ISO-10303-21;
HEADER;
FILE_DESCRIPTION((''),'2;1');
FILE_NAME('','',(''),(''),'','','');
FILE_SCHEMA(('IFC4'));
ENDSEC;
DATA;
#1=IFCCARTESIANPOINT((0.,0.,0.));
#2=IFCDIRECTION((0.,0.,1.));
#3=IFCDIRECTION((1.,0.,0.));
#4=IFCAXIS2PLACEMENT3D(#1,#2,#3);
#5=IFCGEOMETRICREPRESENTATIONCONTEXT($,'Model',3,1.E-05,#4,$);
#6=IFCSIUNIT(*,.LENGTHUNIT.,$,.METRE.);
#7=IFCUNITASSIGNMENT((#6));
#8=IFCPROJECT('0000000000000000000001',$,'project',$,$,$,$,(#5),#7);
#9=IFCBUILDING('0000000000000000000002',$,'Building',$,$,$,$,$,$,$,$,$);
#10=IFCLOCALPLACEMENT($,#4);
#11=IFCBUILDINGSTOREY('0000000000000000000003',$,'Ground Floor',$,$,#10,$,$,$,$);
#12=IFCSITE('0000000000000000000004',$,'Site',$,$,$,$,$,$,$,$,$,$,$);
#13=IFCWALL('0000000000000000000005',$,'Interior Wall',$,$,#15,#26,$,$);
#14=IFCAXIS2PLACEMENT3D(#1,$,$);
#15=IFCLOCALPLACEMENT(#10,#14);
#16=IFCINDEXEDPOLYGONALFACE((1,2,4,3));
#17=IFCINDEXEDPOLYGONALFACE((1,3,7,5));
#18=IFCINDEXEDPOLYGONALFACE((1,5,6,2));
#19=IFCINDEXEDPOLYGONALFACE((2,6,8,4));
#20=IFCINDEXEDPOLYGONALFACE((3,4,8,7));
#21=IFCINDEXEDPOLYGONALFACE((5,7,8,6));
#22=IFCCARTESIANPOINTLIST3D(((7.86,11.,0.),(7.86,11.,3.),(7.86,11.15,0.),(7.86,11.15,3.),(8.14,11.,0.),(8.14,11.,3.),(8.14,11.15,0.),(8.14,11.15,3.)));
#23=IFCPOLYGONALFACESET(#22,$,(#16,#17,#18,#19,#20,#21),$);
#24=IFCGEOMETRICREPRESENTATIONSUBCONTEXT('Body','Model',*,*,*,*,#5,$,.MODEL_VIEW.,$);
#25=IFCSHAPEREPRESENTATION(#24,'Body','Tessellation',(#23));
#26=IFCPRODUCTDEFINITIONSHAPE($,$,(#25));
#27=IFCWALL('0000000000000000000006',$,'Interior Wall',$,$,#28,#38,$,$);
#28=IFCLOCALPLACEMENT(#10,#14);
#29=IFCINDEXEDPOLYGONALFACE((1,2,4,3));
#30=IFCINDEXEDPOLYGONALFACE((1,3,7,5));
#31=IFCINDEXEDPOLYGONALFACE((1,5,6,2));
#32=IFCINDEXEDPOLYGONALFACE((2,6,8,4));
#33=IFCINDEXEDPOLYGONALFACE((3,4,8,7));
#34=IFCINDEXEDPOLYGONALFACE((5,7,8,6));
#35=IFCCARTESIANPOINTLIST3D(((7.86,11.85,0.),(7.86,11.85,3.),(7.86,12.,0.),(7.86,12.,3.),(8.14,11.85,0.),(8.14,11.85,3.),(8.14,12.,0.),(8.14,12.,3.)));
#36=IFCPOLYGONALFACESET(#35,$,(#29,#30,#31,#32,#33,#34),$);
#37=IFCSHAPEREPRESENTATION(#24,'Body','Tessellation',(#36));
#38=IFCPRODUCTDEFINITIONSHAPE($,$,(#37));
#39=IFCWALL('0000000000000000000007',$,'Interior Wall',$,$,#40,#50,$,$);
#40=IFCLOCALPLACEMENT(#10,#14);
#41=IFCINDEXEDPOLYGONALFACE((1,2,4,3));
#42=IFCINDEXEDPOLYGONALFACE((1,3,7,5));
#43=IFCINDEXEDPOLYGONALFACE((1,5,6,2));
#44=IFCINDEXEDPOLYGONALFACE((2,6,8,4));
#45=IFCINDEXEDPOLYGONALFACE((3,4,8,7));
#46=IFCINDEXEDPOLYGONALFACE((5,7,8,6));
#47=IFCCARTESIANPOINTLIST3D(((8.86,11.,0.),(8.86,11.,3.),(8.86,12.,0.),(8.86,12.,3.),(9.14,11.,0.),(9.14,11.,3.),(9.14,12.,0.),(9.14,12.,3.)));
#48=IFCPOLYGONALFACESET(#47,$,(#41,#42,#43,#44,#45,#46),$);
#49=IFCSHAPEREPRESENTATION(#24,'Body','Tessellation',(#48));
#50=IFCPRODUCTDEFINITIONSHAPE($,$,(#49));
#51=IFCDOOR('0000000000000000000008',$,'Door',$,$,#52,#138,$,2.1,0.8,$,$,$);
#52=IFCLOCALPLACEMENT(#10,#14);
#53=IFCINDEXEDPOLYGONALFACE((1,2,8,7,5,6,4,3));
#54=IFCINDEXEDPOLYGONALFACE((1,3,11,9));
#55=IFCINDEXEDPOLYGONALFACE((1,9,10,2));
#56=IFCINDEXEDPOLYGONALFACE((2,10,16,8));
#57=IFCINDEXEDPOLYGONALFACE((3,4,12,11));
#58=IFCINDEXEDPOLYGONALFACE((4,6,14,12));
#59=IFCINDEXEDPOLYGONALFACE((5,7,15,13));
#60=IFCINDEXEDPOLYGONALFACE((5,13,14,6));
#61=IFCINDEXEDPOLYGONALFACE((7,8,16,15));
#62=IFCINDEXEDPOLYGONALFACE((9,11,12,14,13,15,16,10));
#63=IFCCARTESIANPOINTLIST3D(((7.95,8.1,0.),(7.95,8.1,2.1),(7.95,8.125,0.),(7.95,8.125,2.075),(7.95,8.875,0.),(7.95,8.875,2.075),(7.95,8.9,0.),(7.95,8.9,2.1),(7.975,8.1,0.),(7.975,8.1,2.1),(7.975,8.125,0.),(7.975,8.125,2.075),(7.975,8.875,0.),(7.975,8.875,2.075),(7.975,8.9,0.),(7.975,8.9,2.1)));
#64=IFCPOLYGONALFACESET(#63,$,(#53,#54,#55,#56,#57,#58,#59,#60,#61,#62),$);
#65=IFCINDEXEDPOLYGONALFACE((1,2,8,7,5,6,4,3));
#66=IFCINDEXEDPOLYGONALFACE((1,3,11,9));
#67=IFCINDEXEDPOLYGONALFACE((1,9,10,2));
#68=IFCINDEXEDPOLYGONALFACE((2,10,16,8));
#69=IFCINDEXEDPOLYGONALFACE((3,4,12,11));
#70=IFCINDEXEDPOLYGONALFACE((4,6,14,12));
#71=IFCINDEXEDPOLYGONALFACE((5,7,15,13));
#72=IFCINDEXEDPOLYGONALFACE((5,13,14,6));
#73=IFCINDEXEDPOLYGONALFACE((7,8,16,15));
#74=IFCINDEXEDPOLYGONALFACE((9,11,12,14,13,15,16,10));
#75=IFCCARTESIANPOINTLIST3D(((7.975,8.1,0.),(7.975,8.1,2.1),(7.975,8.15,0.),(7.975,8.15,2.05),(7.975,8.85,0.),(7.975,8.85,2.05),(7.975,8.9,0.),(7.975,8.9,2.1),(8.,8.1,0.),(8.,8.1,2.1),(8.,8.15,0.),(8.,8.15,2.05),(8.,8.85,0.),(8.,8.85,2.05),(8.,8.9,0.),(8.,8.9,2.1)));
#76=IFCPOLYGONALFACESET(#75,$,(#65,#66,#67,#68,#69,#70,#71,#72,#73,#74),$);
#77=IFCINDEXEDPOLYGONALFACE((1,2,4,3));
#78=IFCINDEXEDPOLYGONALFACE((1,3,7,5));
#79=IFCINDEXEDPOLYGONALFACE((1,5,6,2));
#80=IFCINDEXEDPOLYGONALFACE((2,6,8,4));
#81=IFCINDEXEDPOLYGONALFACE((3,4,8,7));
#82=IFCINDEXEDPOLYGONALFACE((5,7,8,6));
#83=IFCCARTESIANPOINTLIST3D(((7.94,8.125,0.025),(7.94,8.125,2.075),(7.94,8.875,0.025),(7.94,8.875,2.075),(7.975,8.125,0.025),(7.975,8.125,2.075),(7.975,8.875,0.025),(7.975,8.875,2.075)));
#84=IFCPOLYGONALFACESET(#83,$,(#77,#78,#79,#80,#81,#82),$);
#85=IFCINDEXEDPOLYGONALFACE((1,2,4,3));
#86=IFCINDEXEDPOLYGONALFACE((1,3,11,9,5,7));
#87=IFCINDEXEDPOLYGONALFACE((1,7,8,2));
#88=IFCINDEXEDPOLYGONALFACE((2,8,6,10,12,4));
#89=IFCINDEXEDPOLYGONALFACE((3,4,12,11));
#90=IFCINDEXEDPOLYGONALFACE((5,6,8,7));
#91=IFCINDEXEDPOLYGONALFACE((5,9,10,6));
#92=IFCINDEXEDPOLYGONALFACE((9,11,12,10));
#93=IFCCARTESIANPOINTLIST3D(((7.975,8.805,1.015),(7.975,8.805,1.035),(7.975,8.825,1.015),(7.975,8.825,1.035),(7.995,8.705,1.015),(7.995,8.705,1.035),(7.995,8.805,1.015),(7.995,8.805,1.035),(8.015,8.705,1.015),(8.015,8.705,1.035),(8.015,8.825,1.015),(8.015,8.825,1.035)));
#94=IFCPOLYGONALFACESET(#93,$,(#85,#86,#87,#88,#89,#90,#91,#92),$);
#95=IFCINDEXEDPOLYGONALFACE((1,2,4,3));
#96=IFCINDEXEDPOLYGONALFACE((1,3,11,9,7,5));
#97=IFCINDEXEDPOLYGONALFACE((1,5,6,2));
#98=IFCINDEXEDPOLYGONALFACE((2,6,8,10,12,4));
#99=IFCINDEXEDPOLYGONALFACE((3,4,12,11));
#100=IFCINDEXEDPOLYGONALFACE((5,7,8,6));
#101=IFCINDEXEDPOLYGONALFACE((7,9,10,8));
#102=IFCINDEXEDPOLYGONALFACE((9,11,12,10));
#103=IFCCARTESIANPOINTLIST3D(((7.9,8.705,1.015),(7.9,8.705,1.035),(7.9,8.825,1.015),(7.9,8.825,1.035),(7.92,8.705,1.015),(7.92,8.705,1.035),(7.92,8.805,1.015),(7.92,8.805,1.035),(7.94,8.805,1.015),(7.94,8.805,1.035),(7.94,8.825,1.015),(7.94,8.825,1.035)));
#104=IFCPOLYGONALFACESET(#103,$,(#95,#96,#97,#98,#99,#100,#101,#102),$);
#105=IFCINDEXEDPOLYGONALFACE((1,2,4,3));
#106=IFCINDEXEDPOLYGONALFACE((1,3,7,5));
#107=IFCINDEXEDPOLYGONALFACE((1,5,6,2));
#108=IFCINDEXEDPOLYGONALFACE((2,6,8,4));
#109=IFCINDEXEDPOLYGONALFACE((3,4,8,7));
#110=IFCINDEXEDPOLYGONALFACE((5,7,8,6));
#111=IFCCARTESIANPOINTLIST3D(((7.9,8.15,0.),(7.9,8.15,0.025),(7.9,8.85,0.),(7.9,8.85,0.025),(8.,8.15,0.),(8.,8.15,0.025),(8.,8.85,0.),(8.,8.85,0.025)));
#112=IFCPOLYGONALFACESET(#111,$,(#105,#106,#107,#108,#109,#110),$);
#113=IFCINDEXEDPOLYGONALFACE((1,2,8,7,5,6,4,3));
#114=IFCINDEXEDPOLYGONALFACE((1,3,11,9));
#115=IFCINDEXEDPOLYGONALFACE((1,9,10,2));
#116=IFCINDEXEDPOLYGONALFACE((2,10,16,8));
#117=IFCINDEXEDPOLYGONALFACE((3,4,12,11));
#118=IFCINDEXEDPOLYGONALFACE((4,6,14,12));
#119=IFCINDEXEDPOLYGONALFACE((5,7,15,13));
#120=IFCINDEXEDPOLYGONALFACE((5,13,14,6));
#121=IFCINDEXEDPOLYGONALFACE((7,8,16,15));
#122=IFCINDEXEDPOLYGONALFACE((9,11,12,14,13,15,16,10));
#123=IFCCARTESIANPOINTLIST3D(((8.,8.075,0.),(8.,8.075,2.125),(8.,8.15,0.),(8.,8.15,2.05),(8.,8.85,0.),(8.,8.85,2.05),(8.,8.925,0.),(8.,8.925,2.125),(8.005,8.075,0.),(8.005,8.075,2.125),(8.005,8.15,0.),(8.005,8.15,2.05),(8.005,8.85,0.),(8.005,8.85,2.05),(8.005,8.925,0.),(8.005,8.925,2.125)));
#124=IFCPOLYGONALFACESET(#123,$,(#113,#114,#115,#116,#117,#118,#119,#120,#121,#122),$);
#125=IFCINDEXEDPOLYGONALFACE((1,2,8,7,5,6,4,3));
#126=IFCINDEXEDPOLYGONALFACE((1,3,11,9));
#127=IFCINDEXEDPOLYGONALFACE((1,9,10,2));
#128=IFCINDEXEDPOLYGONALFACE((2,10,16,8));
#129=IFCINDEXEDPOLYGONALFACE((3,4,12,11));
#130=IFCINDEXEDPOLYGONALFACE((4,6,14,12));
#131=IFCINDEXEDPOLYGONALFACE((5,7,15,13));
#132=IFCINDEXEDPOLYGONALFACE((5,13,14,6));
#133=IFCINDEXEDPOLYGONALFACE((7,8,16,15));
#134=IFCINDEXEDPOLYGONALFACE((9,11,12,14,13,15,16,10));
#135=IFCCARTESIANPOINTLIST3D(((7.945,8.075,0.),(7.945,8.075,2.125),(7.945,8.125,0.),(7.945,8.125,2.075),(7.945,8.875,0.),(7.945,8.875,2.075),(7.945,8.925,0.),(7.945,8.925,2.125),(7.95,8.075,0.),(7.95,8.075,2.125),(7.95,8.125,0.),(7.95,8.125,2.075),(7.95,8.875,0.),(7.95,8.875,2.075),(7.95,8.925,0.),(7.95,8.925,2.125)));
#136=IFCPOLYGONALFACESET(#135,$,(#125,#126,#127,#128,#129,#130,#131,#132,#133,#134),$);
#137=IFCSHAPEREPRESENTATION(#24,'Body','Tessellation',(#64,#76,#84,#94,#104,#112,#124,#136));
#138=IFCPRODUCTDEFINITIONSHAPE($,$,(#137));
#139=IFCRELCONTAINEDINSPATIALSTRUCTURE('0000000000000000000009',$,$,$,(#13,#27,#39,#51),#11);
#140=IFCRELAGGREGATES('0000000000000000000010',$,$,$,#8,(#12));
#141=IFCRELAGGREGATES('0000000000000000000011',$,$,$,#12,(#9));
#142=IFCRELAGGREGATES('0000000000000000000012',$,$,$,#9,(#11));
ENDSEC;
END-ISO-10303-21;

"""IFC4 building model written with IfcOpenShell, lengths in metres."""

from ifc_helpers import new_model, si_unit, frame, origin_with_axes, place, context, subcontext, project, spatial, line, indexed_curve, outline, extrude, element, save


model = new_model("IFC4")

# Units and contexts
model_context = context("Model", 3, precision=1e-05, world=origin_with_axes())
body_context = subcontext(model_context, "Body", "Model", "MODEL_VIEW")
ifc_project = project(units=[si_unit("LENGTHUNIT", "METRE")], contexts=[model_context])

# Site, building, storey
site = spatial("IfcSite", under=ifc_project, Name="Site")
building = spatial("IfcBuilding", under=site, Name="Building")
storey_placement = place(None, origin_with_axes())
storey = spatial("IfcBuildingStorey", under=building, at=storey_placement, Name="Ground Floor")

# Walls
for number, where, z_axis, x_axis, name in (
    (1, (8.0, 11.0, 0.0), (0.0, 0.0, 1.0), (0.0, 1.0, 0.0), "Interior Wall"),
    (2, (8.0, 11.85, 0.0), (0.0, 0.0, 1.0), (0.0, 1.0, 0.0), "Interior Wall"),
):
    element("IfcWall", number, at=place(storey_placement, frame(where, z_axis=z_axis, x_axis=x_axis)), inside=storey, Name=name, context=body_context, shape_type="SweptSolid", body=[
        extrude(outline(indexed_curve([(0.0, 0.0), (0.0, 0.28), (0.15, 0.28), (0.15, 0.0), (0.0, 0.0)], self_intersect=False)), frame((0.0, -0.14, 0.0), z_axis=(0.0, 0.0, 1.0), x_axis=(1.0, 0.0, 0.0)), (0.0, 0.0, 1.0), 3.0),
    ])
wall_1_placement = place(storey_placement, frame((9.0, 12.0, 0.0), z_axis=(0.0, 0.0, 1.0), x_axis=(0.0, -1.0, 0.0)))
element("IfcWall", 3, at=wall_1_placement, inside=storey, Name="Interior Wall", context=body_context, shape_type="SweptSolid", body=[
    extrude(outline(indexed_curve([(0.0, 0.0), (0.0, 0.28), (1.0, 0.28), (1.0, 0.0), (0.0, 0.0)], self_intersect=False)), frame((0.0, -0.14, 0.0), z_axis=(0.0, 0.0, 1.0), x_axis=(1.0, 0.0, 0.0)), (0.0, 0.0, 1.0), 3.0),
])

# Door
door_1_placement = place(storey_placement, frame((8.0, 8.1, 0.0), z_axis=(0.0, 0.0, 1.0), x_axis=(0.0, 1.0, 0.0)))
element("IfcDoor", 4, at=door_1_placement, inside=storey, Name="Door", OverallHeight=2.1, OverallWidth=0.8, context=body_context, shape_type="SweptSolid", body=[
    extrude(outline(indexed_curve([(0.0, 0.0), (0.0, 2.1), (0.8, 2.1), (0.8, 0.0), (0.775, 0.0), (0.775, 2.075), (0.025, 2.075), (0.025, 0.0)], segments=[line(1, 2, 3, 4, 5, 6, 7, 8, 1)])), frame((0.0, 0.025, 0.0), z_axis=(0.0, -1.0, 0.0), x_axis=(1.0, 0.0, 0.0)), (0.0, 0.0, -1.0), 0.025),
    extrude(outline(indexed_curve([(0.0, 0.0), (0.0, 2.1), (0.8, 2.1), (0.8, 0.0), (0.75, 0.0), (0.75, 2.05), (0.05, 2.05), (0.05, 0.0)], segments=[line(1, 2, 3, 4, 5, 6, 7, 8, 1)])), frame((0.0, 0.0, 0.0), z_axis=(0.0, -1.0, 0.0), x_axis=(1.0, 0.0, 0.0)), (0.0, 0.0, -1.0), 0.025),
    extrude(outline(indexed_curve([(0.0, 0.0), (0.75, 0.0), (0.75, 0.035), (0.0, 0.035)], segments=[line(1, 2, 3, 4, 1)])), frame((0.025, 0.025, 0.025), z_axis=(0.0, 0.0, 1.0), x_axis=(1.0, 0.0, 0.0)), (0.0, 0.0, 1.0), 2.05),
    extrude(outline(indexed_curve([(0.0, 0.0), (0.0, -0.04), (-0.12, -0.04), (-0.12, -0.02), (-0.02, -0.02), (-0.02, 0.0)], segments=[line(1, 2, 3, 4, 5, 6, 1)])), frame((0.725, 0.025, 1.015), z_axis=(0.0, 0.0, 1.0), x_axis=(1.0, 0.0, 0.0)), (0.0, 0.0, 1.0), 0.02),
    extrude(outline(indexed_curve([(0.0, 0.0), (0.0, 0.04), (-0.12, 0.04), (-0.12, 0.02), (-0.02, 0.02), (-0.02, 0.0)], segments=[line(1, 2, 3, 4, 5, 6, 1)])), frame((0.725, 0.06, 1.015), z_axis=(0.0, 0.0, 1.0), x_axis=(1.0, 0.0, 0.0)), (0.0, 0.0, 1.0), 0.02),
    extrude(outline(indexed_curve([(0.0, 0.0), (0.7, 0.0), (0.7, 0.1), (0.0, 0.1)], segments=[line(1, 2, 3, 4, 1)])), frame((0.05, 0.0, 0.0), z_axis=(0.0, 0.0, 1.0), x_axis=(1.0, 0.0, 0.0)), (0.0, 0.0, 1.0), 0.025),
    extrude(outline(indexed_curve([(0.0, 0.0), (0.0, 2.125), (0.85, 2.125), (0.85, 0.0), (0.775, 0.0), (0.775, 2.05), (0.075, 2.05), (0.075, 0.0)], segments=[line(1, 2, 3, 4, 5, 6, 7, 8, 1)])), frame((-0.025, -0.005, 0.0), z_axis=(0.0, -1.0, 0.0), x_axis=(1.0, 0.0, 0.0)), (0.0, 0.0, -1.0), 0.005),
    extrude(outline(indexed_curve([(0.0, 0.0), (0.0, 2.125), (0.85, 2.125), (0.85, 0.0), (0.8, 0.0), (0.8, 2.075), (0.05, 2.075), (0.05, 0.0)], segments=[line(1, 2, 3, 4, 5, 6, 7, 8, 1)])), frame((-0.025, 0.05, 0.0), z_axis=(0.0, -1.0, 0.0), x_axis=(1.0, 0.0, 0.0)), (0.0, 0.0, -1.0), 0.005),
])

save(model, "model.ifc")
